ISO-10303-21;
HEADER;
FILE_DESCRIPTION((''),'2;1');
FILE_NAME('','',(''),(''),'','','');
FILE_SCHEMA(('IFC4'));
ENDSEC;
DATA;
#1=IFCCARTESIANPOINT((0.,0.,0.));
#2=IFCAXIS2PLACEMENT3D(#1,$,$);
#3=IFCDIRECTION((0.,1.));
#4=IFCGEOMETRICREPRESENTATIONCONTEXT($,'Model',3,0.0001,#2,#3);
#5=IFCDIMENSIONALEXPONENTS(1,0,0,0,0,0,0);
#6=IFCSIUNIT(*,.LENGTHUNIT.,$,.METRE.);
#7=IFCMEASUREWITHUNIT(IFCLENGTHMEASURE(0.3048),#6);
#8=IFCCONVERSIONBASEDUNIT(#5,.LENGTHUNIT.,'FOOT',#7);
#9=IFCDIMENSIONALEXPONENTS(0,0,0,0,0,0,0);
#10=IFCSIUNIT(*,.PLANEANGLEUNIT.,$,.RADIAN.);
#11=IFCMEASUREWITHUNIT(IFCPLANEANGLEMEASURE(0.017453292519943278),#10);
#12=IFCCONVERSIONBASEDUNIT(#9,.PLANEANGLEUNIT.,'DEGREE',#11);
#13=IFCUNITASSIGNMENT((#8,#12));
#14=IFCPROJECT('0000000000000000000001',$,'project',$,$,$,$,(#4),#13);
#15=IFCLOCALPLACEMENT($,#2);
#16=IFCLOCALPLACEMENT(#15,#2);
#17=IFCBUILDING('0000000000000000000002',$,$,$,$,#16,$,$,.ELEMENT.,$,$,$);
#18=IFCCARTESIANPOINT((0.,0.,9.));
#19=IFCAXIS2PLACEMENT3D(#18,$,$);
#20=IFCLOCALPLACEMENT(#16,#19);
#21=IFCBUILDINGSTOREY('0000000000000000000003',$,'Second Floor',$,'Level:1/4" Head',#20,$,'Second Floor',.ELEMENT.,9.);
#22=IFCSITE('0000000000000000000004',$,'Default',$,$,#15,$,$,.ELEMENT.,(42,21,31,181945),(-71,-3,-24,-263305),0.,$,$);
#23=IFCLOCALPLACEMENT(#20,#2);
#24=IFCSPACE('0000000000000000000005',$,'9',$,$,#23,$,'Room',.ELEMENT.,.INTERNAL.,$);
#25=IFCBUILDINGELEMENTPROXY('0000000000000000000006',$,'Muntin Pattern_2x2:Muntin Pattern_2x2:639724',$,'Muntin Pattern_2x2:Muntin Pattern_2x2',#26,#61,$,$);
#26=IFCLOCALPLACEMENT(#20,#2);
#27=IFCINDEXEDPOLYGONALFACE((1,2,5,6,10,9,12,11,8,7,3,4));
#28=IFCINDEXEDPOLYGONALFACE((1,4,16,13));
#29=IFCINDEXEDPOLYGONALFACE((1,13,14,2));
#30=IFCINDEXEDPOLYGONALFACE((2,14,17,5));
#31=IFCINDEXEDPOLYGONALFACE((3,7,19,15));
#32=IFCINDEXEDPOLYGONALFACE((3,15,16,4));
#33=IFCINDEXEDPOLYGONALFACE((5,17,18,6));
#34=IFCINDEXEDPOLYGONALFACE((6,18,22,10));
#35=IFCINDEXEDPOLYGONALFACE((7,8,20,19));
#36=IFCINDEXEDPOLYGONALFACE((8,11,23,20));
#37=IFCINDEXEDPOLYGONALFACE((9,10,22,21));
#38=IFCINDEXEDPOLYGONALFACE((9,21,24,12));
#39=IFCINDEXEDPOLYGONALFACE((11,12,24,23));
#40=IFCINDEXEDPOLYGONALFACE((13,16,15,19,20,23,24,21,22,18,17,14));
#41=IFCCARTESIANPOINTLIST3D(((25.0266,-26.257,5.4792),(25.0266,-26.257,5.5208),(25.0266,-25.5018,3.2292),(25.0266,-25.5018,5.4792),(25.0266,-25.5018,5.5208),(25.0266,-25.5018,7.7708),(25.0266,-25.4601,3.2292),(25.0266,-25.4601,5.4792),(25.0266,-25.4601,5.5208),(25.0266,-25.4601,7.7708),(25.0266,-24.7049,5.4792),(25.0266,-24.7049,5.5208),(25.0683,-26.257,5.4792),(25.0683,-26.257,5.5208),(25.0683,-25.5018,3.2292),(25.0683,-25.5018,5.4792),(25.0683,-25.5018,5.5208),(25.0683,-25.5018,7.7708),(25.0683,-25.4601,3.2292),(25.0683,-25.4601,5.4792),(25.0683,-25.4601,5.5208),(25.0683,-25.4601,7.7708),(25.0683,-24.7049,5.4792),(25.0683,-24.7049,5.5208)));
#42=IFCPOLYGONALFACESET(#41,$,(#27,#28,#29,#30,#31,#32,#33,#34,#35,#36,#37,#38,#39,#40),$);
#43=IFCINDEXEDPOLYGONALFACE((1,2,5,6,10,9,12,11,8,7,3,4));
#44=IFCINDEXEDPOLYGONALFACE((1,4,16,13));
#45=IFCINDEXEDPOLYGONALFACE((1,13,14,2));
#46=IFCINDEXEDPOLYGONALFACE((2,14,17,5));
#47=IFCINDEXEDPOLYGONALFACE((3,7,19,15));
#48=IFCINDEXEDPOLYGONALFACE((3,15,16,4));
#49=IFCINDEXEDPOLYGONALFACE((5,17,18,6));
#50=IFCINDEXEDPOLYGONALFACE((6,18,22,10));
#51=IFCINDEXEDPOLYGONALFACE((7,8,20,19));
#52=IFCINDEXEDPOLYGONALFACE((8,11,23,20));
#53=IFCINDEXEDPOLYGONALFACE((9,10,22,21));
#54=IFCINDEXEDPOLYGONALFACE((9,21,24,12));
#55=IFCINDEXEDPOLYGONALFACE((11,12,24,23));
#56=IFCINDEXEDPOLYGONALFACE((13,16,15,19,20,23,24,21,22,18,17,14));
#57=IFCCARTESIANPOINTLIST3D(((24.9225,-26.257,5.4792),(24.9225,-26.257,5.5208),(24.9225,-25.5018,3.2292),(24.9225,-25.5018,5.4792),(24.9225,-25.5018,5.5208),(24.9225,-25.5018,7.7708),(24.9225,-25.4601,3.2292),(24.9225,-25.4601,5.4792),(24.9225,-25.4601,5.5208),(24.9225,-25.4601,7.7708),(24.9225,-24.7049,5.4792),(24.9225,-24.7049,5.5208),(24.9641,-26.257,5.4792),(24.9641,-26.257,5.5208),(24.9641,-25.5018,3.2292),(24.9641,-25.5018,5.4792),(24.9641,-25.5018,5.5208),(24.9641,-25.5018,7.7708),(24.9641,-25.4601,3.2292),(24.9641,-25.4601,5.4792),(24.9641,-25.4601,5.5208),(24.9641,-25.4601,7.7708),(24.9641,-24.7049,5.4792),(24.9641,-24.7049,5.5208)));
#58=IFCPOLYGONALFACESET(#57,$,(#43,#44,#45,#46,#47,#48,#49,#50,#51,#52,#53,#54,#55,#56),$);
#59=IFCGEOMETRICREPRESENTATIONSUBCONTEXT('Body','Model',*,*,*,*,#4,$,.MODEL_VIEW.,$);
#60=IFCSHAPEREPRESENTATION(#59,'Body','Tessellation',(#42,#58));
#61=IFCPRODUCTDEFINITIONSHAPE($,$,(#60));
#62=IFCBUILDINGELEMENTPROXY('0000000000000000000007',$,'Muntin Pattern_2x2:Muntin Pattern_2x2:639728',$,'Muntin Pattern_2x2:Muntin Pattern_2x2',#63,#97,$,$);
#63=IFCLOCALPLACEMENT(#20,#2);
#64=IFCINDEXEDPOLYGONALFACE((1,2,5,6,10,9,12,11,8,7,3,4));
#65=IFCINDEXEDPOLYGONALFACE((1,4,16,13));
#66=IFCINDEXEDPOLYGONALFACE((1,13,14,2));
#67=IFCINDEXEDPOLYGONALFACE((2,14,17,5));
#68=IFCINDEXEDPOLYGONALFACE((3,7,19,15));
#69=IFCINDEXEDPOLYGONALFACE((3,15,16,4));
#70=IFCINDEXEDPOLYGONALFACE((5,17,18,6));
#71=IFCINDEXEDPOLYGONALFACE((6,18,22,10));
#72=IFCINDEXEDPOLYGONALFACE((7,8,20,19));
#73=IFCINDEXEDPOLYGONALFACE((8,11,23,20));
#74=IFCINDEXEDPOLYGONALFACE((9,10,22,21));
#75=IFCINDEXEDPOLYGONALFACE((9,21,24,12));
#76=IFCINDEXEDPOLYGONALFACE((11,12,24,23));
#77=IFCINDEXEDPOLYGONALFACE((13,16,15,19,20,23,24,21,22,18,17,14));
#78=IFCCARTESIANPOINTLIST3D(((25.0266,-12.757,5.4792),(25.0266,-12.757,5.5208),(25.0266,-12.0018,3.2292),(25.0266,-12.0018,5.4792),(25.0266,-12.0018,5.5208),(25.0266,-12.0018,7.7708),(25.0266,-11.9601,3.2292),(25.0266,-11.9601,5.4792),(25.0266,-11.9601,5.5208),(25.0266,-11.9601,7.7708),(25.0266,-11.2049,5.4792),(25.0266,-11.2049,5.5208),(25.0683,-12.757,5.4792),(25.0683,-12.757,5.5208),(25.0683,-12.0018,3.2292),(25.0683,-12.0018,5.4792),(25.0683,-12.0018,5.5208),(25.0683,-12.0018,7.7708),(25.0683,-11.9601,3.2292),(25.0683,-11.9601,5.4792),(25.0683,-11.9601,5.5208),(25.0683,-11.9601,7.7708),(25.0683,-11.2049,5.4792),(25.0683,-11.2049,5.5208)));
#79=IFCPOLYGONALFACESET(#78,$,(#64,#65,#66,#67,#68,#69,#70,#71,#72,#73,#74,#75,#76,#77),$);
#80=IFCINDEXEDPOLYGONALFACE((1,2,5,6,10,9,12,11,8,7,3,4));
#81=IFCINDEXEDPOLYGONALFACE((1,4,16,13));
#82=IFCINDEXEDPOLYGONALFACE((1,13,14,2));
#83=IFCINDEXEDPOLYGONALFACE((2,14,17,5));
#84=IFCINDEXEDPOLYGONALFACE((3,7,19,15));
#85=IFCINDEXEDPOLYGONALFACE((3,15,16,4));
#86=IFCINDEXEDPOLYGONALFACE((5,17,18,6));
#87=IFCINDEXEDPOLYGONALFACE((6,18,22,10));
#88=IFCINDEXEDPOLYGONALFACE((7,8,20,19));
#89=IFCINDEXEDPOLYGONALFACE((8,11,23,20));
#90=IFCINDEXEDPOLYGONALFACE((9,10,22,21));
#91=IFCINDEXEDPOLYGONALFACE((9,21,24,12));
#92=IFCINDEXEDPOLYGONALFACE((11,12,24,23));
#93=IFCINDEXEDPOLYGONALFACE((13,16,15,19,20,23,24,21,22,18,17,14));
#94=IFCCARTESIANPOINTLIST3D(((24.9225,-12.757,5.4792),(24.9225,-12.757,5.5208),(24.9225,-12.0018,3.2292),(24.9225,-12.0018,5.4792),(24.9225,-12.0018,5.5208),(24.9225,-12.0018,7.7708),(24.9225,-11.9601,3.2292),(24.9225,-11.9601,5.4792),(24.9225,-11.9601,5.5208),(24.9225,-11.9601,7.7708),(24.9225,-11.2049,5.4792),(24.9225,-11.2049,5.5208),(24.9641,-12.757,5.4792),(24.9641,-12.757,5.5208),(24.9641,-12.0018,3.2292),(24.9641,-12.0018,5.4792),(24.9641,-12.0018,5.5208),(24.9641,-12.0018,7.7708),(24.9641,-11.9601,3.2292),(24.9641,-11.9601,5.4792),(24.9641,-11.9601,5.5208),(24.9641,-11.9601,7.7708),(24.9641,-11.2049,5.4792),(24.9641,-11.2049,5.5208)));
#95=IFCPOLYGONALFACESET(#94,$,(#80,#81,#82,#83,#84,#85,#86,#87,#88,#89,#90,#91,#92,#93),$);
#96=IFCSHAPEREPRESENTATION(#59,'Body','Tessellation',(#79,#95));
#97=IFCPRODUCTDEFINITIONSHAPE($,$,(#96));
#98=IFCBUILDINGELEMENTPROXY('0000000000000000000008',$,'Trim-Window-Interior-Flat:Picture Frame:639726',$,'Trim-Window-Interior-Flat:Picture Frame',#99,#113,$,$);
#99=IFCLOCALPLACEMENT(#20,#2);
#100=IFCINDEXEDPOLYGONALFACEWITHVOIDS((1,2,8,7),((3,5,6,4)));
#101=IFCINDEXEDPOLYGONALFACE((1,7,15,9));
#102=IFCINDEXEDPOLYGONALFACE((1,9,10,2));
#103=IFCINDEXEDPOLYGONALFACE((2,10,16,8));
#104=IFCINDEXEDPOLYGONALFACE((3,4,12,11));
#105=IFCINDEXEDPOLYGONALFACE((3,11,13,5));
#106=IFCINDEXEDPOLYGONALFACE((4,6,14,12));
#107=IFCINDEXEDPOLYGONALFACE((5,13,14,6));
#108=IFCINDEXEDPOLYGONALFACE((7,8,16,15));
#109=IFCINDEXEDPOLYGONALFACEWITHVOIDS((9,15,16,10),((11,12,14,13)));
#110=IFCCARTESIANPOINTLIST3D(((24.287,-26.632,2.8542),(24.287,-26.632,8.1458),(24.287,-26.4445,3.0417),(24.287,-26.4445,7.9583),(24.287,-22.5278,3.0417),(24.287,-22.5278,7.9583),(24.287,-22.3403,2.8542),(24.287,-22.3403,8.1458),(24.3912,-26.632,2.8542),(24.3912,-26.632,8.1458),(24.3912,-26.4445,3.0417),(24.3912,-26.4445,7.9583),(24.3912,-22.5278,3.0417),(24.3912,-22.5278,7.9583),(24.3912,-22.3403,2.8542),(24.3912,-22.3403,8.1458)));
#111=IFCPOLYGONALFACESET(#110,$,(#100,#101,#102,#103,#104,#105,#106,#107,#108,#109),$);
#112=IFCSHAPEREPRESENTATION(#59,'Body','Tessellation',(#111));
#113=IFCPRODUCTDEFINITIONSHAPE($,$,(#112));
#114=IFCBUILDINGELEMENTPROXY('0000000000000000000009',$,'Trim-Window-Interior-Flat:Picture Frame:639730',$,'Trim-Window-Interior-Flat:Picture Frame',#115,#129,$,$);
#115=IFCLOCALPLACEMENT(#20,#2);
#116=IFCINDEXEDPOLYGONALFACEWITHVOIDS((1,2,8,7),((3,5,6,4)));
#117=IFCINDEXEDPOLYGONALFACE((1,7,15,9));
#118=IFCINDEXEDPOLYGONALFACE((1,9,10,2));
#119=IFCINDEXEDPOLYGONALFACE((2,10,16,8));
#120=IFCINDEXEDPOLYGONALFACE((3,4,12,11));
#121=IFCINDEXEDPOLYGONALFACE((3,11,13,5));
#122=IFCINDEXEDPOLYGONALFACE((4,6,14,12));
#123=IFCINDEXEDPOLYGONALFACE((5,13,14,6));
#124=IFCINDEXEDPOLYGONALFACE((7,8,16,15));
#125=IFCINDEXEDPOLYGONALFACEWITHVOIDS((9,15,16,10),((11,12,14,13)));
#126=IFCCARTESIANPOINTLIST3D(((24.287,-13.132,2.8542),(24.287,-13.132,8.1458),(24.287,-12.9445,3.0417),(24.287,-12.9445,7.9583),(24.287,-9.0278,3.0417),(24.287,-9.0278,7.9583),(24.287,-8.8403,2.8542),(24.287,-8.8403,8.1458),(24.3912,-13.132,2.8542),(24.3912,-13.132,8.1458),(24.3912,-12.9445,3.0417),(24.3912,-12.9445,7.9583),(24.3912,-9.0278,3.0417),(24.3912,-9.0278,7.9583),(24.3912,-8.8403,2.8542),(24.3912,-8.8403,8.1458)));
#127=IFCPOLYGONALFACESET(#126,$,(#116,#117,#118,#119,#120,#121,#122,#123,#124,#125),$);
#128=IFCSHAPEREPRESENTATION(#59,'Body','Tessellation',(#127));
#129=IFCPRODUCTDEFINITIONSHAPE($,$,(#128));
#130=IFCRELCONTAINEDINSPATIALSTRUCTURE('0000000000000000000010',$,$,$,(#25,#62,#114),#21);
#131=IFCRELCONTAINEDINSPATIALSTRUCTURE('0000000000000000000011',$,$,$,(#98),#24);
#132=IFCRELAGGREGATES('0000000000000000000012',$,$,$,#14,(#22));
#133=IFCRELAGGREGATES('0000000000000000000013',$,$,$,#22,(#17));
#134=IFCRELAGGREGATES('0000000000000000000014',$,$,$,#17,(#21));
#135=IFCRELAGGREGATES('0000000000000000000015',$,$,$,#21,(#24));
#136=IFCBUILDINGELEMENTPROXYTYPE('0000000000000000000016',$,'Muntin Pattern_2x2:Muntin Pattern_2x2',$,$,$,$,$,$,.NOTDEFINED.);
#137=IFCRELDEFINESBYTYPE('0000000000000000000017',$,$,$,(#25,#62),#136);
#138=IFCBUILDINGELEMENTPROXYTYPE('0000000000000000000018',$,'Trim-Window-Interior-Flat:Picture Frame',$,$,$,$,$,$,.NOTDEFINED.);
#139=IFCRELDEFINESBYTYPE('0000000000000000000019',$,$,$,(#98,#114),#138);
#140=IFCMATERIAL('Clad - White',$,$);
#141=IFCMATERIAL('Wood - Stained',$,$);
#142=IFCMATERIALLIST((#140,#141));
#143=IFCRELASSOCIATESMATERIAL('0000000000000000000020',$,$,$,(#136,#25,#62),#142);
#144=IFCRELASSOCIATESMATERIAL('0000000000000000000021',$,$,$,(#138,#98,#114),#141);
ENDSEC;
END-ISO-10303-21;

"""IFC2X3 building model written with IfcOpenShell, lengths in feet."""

from ifc_helpers import new_model, entity, si_unit, converted_unit, direction, frame, origin, place, context, subcontext, project, spatial, polyline, outline, extrude, source, transform, mapped, material, material_list, type_object, type_shapes, element, save


model = new_model("IFC2X3")

# Units and contexts
model_context = context("Model", 3, precision=0.0001, world=origin(), true_north=direction((0.0, 1.0)))
body_context = subcontext(model_context, "Body", "Model", "MODEL_VIEW")
ifc_project = project(units=[converted_unit("LENGTHUNIT", "FOOT", entity("IfcLengthMeasure", 0.3048), si_unit("LENGTHUNIT", "METRE"), dimensions=[1, 0, 0, 0, 0, 0, 0]), converted_unit("PLANEANGLEUNIT", "DEGREE", entity("IfcPlaneAngleMeasure", 0.017453292519943278), si_unit("PLANEANGLEUNIT", "RADIAN"), dimensions=[0, 0, 0, 0, 0, 0, 0])], contexts=[model_context])

# Site, building, storey
site_placement = place(None, origin())
site = spatial("IfcSite", under=ifc_project, at=site_placement, Name="Default", CompositionType="ELEMENT", RefLatitude=(42, 21, 31, 181945), RefLongitude=(-71, -3, -24, -263305), RefElevation=0.0)
building_placement = place(site_placement, origin())
building = spatial("IfcBuilding", under=site, at=building_placement, CompositionType="ELEMENT")
storey_placement = place(building_placement, frame((0.0, 0.0, 9.0)))
storey = spatial("IfcBuildingStorey", under=building, at=storey_placement, Name="Second Floor", ObjectType="Level:1/4\" Head", LongName="Second Floor", CompositionType="ELEMENT", Elevation=9.0)

# Shared definitions
space_placement = place(storey_placement, origin())
space = spatial("IfcSpace", under=storey, at=space_placement, Name="9", LongName="Room", CompositionType="ELEMENT", InteriorOrExteriorSpace="INTERNAL")

# Building element proxies
ifc_material_1 = material(Name="Clad - White")
ifc_material_2 = material(Name="Wood - Stained")
ifc_material_list_1 = material_list([ifc_material_1, ifc_material_2])
building_element_proxy_type_1 = type_object("IfcBuildingElementProxyType", Name="Muntin Pattern_2x2:Muntin Pattern_2x2", PredefinedType="NOTDEFINED", material=ifc_material_list_1)
shared_shape_1 = source(origin(), body_context, "Body", "SweptSolid", [
    extrude(outline(polyline([(0.0208, -0.0208), (2.2708, -0.0208), (2.2708, 0.0208), (0.0208, 0.0208), (0.0208, 0.776), (-0.0208, 0.776), (-0.0208, 0.0208), (-2.2708, 0.0208), (-2.2708, -0.0208), (-0.0208, -0.0208), (-0.0208, -0.776), (0.0208, -0.776), (0.0208, -0.0208)])), frame((0.0, -0.0729, 2.2708), z_axis=(0.0, 1.0, 0.0), x_axis=(0.0, 0.0, 1.0)), (0.0, 0.0, 1.0), 0.0417),
    extrude(outline(polyline([(0.0208, -0.0208), (2.2708, -0.0208), (2.2708, 0.0208), (0.0208, 0.0208), (0.0208, 0.776), (-0.0208, 0.776), (-0.0208, 0.0208), (-2.2708, 0.0208), (-2.2708, -0.0208), (-0.0208, -0.0208), (-0.0208, -0.776), (0.0208, -0.776), (0.0208, -0.0208)])), frame((0.0, 0.0313, 2.2708), z_axis=(0.0, 1.0, 0.0), x_axis=(0.0, 0.0, 1.0)), (0.0, 0.0, 1.0), 0.0417),
])
type_shapes(building_element_proxy_type_1, [shared_shape_1])
for number, where, z_axis, x_axis, name in (
    (1, (24.9954, -25.4809, 3.2292), (0.0, 0.0, 1.0), (0.0, 1.0, 0.0), "Muntin Pattern_2x2:Muntin Pattern_2x2:639724"),
    (2, (24.9954, -11.9809, 3.2292), (0.0, 0.0, 1.0), (0.0, 1.0, 0.0), "Muntin Pattern_2x2:Muntin Pattern_2x2:639728"),
):
    element("IfcBuildingElementProxy", number, at=place(storey_placement, frame(where, z_axis=z_axis, x_axis=x_axis)), inside=storey, type_object=building_element_proxy_type_1, material=ifc_material_list_1, Name=name, ObjectType="Muntin Pattern_2x2:Muntin Pattern_2x2", context=body_context, shape_type="MappedRepresentation", body=[
        mapped(shared_shape_1, transform((0.0, 0.0, 0.0), scale=1.0)),
    ])
building_element_proxy_type_2 = type_object("IfcBuildingElementProxyType", Name="Trim-Window-Interior-Flat:Picture Frame", PredefinedType="NOTDEFINED", material=ifc_material_2)
shared_shape_2 = source(origin(), body_context, "Body", "SweptSolid", [
    extrude(outline(polyline([(-2.1458, -2.6458), (2.1458, -2.6458), (2.1458, 2.6458), (-2.1458, 2.6458), (-2.1458, -2.6458)]), holes=[polyline([(-1.9583, -2.4583), (-1.9583, 2.4583), (1.9583, 2.4583), (1.9583, -2.4583), (-1.9583, -2.4583)])]), frame((0.0, -2.5, 0.0), z_axis=(0.0, 0.0, 1.0), x_axis=(-1.0, 0.0, 0.0)), (0.0, 0.0, 1.0), 0.1042),
])
type_shapes(building_element_proxy_type_2, [shared_shape_2])
proxy_1_placement = place(space_placement, frame((24.3912, -24.4861, 8.0), z_axis=(-1.0, 0.0, 0.0), x_axis=(0.0, -1.0, 0.0)))
element("IfcBuildingElementProxy", 3, at=proxy_1_placement, inside=space, type_object=building_element_proxy_type_2, material=ifc_material_2, Name="Trim-Window-Interior-Flat:Picture Frame:639726", ObjectType="Trim-Window-Interior-Flat:Picture Frame", context=body_context, shape_type="MappedRepresentation", body=[
    mapped(shared_shape_2, transform((0.0, 0.0, 0.0), scale=1.0)),
])
proxy_2_placement = place(storey_placement, frame((24.3912, -10.9861, 8.0), z_axis=(-1.0, 0.0, 0.0), x_axis=(0.0, -1.0, 0.0)))
element("IfcBuildingElementProxy", 4, at=proxy_2_placement, inside=storey, type_object=building_element_proxy_type_2, material=ifc_material_2, Name="Trim-Window-Interior-Flat:Picture Frame:639730", ObjectType="Trim-Window-Interior-Flat:Picture Frame", context=body_context, shape_type="MappedRepresentation", body=[
    mapped(shared_shape_2, transform((0.0, 0.0, 0.0), scale=1.0)),
])

save(model, "model.ifc")
